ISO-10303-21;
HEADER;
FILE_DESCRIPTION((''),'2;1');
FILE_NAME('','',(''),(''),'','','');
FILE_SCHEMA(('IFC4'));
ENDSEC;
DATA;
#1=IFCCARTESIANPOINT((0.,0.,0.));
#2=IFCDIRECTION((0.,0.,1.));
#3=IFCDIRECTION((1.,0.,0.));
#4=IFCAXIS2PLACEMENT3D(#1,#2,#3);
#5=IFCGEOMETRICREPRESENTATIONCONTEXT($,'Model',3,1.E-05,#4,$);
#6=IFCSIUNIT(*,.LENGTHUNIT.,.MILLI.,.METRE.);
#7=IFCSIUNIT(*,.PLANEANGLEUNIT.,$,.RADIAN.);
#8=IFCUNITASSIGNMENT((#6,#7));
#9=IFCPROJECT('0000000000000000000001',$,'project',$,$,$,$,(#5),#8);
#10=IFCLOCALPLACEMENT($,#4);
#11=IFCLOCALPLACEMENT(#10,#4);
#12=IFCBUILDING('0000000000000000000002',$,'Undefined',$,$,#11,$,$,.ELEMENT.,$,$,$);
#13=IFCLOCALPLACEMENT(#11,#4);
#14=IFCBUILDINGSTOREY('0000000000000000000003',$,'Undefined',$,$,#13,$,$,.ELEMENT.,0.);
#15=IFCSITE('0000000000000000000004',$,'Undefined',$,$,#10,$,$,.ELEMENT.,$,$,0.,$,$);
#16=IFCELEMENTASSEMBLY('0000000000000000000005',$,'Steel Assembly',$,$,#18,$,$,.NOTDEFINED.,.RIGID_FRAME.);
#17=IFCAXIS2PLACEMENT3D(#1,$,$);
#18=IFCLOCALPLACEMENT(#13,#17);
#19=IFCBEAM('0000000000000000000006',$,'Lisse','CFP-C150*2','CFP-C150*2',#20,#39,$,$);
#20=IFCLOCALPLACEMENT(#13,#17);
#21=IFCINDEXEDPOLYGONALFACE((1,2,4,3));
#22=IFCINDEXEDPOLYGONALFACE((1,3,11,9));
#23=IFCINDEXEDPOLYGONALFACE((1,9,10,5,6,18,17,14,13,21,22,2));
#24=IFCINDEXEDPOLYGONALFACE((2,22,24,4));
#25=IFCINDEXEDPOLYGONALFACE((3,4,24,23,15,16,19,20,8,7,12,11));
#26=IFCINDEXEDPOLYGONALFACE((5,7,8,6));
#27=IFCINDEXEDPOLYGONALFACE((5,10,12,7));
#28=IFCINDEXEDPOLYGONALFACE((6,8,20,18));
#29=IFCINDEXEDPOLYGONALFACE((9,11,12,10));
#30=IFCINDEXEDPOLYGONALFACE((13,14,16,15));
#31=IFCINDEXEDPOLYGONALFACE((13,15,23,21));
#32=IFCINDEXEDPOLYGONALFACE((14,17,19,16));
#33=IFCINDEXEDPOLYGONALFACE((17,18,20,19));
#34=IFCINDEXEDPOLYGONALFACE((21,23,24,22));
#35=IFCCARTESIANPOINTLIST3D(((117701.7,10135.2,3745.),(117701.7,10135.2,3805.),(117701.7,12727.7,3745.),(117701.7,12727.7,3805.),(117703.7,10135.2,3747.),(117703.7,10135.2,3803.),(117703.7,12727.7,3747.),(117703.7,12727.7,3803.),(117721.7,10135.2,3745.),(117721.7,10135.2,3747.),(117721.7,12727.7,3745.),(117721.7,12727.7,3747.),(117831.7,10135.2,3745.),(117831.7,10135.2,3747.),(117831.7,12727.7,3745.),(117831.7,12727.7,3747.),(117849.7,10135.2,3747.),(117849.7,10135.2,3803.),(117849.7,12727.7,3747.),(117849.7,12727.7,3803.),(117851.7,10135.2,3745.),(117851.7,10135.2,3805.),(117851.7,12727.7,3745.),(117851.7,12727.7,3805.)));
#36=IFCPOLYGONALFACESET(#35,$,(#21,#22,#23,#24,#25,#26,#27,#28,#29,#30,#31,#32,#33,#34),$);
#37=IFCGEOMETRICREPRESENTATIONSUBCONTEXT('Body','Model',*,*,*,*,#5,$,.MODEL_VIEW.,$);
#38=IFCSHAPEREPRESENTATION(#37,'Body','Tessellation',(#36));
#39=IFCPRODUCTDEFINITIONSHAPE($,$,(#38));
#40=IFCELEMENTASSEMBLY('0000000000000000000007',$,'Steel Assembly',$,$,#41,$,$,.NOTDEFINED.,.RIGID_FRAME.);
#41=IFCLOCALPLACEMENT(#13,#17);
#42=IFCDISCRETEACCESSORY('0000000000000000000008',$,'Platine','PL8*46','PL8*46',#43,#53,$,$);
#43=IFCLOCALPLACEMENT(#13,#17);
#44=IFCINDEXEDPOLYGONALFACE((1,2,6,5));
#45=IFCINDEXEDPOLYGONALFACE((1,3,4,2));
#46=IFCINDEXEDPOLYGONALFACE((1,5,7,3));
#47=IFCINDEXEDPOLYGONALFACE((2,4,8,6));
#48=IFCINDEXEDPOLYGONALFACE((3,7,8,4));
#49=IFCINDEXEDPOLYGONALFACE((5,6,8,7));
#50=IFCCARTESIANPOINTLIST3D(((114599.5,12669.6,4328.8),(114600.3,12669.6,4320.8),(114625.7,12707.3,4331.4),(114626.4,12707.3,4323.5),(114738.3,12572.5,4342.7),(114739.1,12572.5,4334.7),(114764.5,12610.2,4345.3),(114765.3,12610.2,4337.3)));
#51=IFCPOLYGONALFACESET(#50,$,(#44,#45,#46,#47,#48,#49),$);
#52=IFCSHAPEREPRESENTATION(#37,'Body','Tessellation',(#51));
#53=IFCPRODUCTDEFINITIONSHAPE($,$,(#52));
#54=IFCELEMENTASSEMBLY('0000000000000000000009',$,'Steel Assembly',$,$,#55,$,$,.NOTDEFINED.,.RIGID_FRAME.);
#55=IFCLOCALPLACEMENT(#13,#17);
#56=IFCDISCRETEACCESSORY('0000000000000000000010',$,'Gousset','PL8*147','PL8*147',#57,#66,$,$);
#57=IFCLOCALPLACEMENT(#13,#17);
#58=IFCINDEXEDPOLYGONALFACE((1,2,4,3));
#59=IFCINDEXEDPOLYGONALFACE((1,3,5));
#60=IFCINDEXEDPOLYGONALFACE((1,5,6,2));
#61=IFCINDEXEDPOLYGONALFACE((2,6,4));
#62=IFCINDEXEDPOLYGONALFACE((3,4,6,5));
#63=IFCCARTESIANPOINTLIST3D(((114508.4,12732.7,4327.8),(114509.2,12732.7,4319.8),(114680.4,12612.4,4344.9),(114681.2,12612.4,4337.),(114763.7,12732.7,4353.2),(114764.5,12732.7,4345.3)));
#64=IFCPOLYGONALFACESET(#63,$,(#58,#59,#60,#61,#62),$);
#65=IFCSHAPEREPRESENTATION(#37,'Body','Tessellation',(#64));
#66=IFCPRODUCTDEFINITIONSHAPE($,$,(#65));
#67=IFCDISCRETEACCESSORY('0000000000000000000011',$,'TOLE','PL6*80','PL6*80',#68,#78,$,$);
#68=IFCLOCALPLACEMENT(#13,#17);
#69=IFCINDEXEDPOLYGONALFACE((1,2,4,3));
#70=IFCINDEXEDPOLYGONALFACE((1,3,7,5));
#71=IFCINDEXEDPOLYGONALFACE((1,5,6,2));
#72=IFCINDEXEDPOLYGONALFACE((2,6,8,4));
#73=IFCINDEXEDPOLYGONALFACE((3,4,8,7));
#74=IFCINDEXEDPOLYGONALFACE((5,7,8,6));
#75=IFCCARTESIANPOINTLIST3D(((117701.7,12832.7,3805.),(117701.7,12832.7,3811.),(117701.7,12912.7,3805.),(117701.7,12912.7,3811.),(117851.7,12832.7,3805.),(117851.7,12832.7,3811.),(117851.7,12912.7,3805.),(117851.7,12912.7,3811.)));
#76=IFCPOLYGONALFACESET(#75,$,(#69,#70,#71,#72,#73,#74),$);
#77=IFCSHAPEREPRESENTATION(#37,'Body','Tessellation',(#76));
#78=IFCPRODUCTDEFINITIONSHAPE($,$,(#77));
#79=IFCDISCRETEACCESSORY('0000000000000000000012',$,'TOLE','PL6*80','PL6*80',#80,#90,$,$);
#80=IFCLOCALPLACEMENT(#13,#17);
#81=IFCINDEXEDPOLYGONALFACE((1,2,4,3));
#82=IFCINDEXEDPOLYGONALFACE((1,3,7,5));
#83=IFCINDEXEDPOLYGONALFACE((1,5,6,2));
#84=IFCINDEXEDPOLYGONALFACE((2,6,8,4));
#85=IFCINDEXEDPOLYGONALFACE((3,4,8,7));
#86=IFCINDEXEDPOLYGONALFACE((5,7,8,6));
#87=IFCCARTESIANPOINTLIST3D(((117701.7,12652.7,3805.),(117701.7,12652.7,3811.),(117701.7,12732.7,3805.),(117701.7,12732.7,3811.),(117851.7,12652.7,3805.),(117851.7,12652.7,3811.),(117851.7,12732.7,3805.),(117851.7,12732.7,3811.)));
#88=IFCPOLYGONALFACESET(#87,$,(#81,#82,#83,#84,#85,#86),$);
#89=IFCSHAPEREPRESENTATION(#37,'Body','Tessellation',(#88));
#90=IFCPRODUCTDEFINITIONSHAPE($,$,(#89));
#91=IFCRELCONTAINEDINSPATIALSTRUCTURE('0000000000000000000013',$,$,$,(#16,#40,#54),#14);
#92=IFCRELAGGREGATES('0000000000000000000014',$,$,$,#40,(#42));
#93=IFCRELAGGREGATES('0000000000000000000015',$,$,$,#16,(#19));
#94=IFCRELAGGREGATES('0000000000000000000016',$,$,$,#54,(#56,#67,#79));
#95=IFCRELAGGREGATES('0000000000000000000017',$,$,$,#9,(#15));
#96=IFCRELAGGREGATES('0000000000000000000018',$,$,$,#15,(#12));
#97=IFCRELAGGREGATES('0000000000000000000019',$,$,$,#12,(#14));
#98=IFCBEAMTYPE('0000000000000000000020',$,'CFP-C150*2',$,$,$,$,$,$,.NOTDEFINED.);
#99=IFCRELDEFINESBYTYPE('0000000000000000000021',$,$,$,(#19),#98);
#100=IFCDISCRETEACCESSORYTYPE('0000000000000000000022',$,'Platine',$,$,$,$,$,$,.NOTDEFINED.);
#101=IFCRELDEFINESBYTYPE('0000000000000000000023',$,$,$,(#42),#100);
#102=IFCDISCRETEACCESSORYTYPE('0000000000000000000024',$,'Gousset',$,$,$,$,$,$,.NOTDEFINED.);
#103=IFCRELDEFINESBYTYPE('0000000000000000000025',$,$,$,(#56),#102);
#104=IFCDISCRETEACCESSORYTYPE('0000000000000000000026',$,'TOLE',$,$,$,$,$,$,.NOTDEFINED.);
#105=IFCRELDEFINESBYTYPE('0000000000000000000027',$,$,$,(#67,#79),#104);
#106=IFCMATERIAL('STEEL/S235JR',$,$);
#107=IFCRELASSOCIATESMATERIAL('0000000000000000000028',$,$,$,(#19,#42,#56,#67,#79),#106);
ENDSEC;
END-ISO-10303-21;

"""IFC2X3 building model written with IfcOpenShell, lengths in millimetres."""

from ifc_helpers import new_model, si_unit, frame, origin_with_axes, origin_2d_with_axis, place, context, subcontext, project, spatial, polyline, c_section, outline, extrude, material, type_object, element, aggregate, save


model = new_model("IFC2X3")

# Units and contexts
model_context = context("Model", 3, precision=1e-05, world=origin_with_axes())
body_context = subcontext(model_context, "Body", "Model", "MODEL_VIEW")
ifc_project = project(units=[si_unit("LENGTHUNIT", "METRE", prefix="MILLI"), si_unit("PLANEANGLEUNIT", "RADIAN")], contexts=[model_context])

# Site, building, storey
site_placement = place(None, origin_with_axes())
site = spatial("IfcSite", under=ifc_project, at=site_placement, Name="Undefined", CompositionType="ELEMENT", RefElevation=0.0)
building_placement = place(site_placement, origin_with_axes())
building = spatial("IfcBuilding", under=site, at=building_placement, Name="Undefined", CompositionType="ELEMENT")
storey_placement = place(building_placement, origin_with_axes())
storey = spatial("IfcBuildingStorey", under=building, at=storey_placement, Name="Undefined", CompositionType="ELEMENT", Elevation=0.0)

# Shared definitions
ifc_material_1 = material(Name="STEEL/S235JR")

# Element assembly, beam
assembly_1_placement = place(storey_placement, origin_with_axes())
assembly_1 = element("IfcElementAssembly", 1, at=assembly_1_placement, inside=storey, Name="Steel Assembly", AssemblyPlace="NOTDEFINED", PredefinedType="RIGID_FRAME")
beam_type = type_object("IfcBeamType", Name="CFP-C150*2", PredefinedType="NOTDEFINED")
beam_placement = place(assembly_1_placement, frame((117776.7, 12782.2, 3775.0), z_axis=(-1.0, 0.0, 0.0), x_axis=(0.0, -1.0, 0.0)))
beam = element("IfcBeam", 2, at=beam_placement, type_object=beam_type, material=ifc_material_1, Name="Lisse", Description="CFP-C150*2", ObjectType="CFP-C150*2", context=body_context, shape_type="SweptSolid", body=[
    extrude(c_section(Depth=150.0, Width=60.0, WallThickness=2.0, Girth=20.0, at=origin_2d_with_axis()), frame((2647.0, 0.0, 0.0), z_axis=(-1.0, 0.0, 0.0), x_axis=(0.0, -1.0, 0.0)), (0.0, 0.0, 1.0), 2592.5),
])

# Element assembly, discrete accessory
assembly_2_placement = place(storey_placement, origin_with_axes())
assembly_2 = element("IfcElementAssembly", 3, at=assembly_2_placement, inside=storey, Name="Steel Assembly", AssemblyPlace="NOTDEFINED", PredefinedType="RIGID_FRAME")
discrete_accessory_type_1 = type_object("IfcDiscreteAccessoryType", Name="Platine")
discrete_accessory_1_placement = place(assembly_2_placement, frame((114613.0, 12688.4, 4326.1), z_axis=(-0.099342, 0.0, 0.995053), x_axis=(0.816707, -0.571264, 0.081537)))
discrete_accessory_1 = element("IfcDiscreteAccessory", 4, at=discrete_accessory_1_placement, type_object=discrete_accessory_type_1, material=ifc_material_1, Name="Platine", Description="PL8*46", ObjectType="PL8*46", context=body_context, shape_type="SweptSolid", body=[
    extrude(outline(polyline([(0.0, 23.0), (170.0, 23.0), (170.0, -23.0), (0.0, -23.0), (0.0, 23.0)])), frame((0.0, 0.0, -4.0), z_axis=(0.0, 0.0, 1.0), x_axis=(1.0, 0.0, 0.0)), (0.0, 0.0, 1.0), 8.0),
])

# Element assembly, discrete accessory
assembly_3_placement = place(storey_placement, origin_with_axes())
assembly_3 = element("IfcElementAssembly", 5, at=assembly_3_placement, inside=storey, Name="Steel Assembly", AssemblyPlace="NOTDEFINED", PredefinedType="RIGID_FRAME")
discrete_accessory_type_2 = type_object("IfcDiscreteAccessoryType", Name="Gousset")
discrete_accessory_2_placement = place(assembly_3_placement, frame((114508.8, 12732.7, 4323.8), z_axis=(-0.099342, 0.0, 0.995053), x_axis=(0.816707, -0.571264, 0.081537)))
discrete_accessory_2 = element("IfcDiscreteAccessory", 6, at=discrete_accessory_2_placement, type_object=discrete_accessory_type_2, material=ifc_material_1, Name="Gousset", Description="PL8*147", ObjectType="PL8*147", context=body_context, shape_type="SweptSolid", body=[
    extrude(outline(polyline([(0.0, 0.0), (210.6, 0.0), (210.6, 146.5), (0.0, 0.0)])), frame((0.0, 0.0, -4.0), z_axis=(0.0, 0.0, 1.0), x_axis=(1.0, 0.0, 0.0)), (0.0, 0.0, 1.0), 8.0),
])

# Discrete accessories
aggregate(assembly_2, [discrete_accessory_1])
discrete_accessory_type_3 = type_object("IfcDiscreteAccessoryType", Name="TOLE")
discrete_accessory_3_placement = place(assembly_3_placement, frame((117851.7, 12872.7, 3808.0), z_axis=(0.0, 0.0, 1.0), x_axis=(-1.0, 0.000045, 0.0)))
discrete_accessory_3 = element("IfcDiscreteAccessory", 7, at=discrete_accessory_3_placement, type_object=discrete_accessory_type_3, material=ifc_material_1, Name="TOLE", Description="PL6*80", ObjectType="PL6*80", context=body_context, shape_type="SweptSolid", body=[
    extrude(outline(polyline([(150.0, -40.0), (0.0, -40.0), (0.0, 40.0), (150.0, 40.0), (150.0, -40.0)])), frame((0.0, 0.0, -3.0), z_axis=(0.0, 0.0, 1.0), x_axis=(1.0, 0.0, 0.0)), (0.0, 0.0, 1.0), 6.0),
])
discrete_accessory_4_placement = place(assembly_3_placement, frame((117851.7, 12692.7, 3808.0), z_axis=(0.0, 0.0, -1.0), x_axis=(-1.0, 0.000045, 0.0)))
discrete_accessory_4 = element("IfcDiscreteAccessory", 8, at=discrete_accessory_4_placement, type_object=discrete_accessory_type_3, material=ifc_material_1, Name="TOLE", Description="PL6*80", ObjectType="PL6*80", context=body_context, shape_type="SweptSolid", body=[
    extrude(outline(polyline([(0.0, -40.0), (0.0, 40.0), (150.0, 40.0), (150.0, -40.0), (0.0, -40.0)])), frame((0.0, 0.0, -3.0), z_axis=(0.0, 0.0, 1.0), x_axis=(1.0, 0.0, 0.0)), (0.0, 0.0, 1.0), 6.0),
])

aggregate(assembly_1, [beam])

aggregate(assembly_3, [discrete_accessory_2, discrete_accessory_3, discrete_accessory_4])

save(model, "model.ifc")
